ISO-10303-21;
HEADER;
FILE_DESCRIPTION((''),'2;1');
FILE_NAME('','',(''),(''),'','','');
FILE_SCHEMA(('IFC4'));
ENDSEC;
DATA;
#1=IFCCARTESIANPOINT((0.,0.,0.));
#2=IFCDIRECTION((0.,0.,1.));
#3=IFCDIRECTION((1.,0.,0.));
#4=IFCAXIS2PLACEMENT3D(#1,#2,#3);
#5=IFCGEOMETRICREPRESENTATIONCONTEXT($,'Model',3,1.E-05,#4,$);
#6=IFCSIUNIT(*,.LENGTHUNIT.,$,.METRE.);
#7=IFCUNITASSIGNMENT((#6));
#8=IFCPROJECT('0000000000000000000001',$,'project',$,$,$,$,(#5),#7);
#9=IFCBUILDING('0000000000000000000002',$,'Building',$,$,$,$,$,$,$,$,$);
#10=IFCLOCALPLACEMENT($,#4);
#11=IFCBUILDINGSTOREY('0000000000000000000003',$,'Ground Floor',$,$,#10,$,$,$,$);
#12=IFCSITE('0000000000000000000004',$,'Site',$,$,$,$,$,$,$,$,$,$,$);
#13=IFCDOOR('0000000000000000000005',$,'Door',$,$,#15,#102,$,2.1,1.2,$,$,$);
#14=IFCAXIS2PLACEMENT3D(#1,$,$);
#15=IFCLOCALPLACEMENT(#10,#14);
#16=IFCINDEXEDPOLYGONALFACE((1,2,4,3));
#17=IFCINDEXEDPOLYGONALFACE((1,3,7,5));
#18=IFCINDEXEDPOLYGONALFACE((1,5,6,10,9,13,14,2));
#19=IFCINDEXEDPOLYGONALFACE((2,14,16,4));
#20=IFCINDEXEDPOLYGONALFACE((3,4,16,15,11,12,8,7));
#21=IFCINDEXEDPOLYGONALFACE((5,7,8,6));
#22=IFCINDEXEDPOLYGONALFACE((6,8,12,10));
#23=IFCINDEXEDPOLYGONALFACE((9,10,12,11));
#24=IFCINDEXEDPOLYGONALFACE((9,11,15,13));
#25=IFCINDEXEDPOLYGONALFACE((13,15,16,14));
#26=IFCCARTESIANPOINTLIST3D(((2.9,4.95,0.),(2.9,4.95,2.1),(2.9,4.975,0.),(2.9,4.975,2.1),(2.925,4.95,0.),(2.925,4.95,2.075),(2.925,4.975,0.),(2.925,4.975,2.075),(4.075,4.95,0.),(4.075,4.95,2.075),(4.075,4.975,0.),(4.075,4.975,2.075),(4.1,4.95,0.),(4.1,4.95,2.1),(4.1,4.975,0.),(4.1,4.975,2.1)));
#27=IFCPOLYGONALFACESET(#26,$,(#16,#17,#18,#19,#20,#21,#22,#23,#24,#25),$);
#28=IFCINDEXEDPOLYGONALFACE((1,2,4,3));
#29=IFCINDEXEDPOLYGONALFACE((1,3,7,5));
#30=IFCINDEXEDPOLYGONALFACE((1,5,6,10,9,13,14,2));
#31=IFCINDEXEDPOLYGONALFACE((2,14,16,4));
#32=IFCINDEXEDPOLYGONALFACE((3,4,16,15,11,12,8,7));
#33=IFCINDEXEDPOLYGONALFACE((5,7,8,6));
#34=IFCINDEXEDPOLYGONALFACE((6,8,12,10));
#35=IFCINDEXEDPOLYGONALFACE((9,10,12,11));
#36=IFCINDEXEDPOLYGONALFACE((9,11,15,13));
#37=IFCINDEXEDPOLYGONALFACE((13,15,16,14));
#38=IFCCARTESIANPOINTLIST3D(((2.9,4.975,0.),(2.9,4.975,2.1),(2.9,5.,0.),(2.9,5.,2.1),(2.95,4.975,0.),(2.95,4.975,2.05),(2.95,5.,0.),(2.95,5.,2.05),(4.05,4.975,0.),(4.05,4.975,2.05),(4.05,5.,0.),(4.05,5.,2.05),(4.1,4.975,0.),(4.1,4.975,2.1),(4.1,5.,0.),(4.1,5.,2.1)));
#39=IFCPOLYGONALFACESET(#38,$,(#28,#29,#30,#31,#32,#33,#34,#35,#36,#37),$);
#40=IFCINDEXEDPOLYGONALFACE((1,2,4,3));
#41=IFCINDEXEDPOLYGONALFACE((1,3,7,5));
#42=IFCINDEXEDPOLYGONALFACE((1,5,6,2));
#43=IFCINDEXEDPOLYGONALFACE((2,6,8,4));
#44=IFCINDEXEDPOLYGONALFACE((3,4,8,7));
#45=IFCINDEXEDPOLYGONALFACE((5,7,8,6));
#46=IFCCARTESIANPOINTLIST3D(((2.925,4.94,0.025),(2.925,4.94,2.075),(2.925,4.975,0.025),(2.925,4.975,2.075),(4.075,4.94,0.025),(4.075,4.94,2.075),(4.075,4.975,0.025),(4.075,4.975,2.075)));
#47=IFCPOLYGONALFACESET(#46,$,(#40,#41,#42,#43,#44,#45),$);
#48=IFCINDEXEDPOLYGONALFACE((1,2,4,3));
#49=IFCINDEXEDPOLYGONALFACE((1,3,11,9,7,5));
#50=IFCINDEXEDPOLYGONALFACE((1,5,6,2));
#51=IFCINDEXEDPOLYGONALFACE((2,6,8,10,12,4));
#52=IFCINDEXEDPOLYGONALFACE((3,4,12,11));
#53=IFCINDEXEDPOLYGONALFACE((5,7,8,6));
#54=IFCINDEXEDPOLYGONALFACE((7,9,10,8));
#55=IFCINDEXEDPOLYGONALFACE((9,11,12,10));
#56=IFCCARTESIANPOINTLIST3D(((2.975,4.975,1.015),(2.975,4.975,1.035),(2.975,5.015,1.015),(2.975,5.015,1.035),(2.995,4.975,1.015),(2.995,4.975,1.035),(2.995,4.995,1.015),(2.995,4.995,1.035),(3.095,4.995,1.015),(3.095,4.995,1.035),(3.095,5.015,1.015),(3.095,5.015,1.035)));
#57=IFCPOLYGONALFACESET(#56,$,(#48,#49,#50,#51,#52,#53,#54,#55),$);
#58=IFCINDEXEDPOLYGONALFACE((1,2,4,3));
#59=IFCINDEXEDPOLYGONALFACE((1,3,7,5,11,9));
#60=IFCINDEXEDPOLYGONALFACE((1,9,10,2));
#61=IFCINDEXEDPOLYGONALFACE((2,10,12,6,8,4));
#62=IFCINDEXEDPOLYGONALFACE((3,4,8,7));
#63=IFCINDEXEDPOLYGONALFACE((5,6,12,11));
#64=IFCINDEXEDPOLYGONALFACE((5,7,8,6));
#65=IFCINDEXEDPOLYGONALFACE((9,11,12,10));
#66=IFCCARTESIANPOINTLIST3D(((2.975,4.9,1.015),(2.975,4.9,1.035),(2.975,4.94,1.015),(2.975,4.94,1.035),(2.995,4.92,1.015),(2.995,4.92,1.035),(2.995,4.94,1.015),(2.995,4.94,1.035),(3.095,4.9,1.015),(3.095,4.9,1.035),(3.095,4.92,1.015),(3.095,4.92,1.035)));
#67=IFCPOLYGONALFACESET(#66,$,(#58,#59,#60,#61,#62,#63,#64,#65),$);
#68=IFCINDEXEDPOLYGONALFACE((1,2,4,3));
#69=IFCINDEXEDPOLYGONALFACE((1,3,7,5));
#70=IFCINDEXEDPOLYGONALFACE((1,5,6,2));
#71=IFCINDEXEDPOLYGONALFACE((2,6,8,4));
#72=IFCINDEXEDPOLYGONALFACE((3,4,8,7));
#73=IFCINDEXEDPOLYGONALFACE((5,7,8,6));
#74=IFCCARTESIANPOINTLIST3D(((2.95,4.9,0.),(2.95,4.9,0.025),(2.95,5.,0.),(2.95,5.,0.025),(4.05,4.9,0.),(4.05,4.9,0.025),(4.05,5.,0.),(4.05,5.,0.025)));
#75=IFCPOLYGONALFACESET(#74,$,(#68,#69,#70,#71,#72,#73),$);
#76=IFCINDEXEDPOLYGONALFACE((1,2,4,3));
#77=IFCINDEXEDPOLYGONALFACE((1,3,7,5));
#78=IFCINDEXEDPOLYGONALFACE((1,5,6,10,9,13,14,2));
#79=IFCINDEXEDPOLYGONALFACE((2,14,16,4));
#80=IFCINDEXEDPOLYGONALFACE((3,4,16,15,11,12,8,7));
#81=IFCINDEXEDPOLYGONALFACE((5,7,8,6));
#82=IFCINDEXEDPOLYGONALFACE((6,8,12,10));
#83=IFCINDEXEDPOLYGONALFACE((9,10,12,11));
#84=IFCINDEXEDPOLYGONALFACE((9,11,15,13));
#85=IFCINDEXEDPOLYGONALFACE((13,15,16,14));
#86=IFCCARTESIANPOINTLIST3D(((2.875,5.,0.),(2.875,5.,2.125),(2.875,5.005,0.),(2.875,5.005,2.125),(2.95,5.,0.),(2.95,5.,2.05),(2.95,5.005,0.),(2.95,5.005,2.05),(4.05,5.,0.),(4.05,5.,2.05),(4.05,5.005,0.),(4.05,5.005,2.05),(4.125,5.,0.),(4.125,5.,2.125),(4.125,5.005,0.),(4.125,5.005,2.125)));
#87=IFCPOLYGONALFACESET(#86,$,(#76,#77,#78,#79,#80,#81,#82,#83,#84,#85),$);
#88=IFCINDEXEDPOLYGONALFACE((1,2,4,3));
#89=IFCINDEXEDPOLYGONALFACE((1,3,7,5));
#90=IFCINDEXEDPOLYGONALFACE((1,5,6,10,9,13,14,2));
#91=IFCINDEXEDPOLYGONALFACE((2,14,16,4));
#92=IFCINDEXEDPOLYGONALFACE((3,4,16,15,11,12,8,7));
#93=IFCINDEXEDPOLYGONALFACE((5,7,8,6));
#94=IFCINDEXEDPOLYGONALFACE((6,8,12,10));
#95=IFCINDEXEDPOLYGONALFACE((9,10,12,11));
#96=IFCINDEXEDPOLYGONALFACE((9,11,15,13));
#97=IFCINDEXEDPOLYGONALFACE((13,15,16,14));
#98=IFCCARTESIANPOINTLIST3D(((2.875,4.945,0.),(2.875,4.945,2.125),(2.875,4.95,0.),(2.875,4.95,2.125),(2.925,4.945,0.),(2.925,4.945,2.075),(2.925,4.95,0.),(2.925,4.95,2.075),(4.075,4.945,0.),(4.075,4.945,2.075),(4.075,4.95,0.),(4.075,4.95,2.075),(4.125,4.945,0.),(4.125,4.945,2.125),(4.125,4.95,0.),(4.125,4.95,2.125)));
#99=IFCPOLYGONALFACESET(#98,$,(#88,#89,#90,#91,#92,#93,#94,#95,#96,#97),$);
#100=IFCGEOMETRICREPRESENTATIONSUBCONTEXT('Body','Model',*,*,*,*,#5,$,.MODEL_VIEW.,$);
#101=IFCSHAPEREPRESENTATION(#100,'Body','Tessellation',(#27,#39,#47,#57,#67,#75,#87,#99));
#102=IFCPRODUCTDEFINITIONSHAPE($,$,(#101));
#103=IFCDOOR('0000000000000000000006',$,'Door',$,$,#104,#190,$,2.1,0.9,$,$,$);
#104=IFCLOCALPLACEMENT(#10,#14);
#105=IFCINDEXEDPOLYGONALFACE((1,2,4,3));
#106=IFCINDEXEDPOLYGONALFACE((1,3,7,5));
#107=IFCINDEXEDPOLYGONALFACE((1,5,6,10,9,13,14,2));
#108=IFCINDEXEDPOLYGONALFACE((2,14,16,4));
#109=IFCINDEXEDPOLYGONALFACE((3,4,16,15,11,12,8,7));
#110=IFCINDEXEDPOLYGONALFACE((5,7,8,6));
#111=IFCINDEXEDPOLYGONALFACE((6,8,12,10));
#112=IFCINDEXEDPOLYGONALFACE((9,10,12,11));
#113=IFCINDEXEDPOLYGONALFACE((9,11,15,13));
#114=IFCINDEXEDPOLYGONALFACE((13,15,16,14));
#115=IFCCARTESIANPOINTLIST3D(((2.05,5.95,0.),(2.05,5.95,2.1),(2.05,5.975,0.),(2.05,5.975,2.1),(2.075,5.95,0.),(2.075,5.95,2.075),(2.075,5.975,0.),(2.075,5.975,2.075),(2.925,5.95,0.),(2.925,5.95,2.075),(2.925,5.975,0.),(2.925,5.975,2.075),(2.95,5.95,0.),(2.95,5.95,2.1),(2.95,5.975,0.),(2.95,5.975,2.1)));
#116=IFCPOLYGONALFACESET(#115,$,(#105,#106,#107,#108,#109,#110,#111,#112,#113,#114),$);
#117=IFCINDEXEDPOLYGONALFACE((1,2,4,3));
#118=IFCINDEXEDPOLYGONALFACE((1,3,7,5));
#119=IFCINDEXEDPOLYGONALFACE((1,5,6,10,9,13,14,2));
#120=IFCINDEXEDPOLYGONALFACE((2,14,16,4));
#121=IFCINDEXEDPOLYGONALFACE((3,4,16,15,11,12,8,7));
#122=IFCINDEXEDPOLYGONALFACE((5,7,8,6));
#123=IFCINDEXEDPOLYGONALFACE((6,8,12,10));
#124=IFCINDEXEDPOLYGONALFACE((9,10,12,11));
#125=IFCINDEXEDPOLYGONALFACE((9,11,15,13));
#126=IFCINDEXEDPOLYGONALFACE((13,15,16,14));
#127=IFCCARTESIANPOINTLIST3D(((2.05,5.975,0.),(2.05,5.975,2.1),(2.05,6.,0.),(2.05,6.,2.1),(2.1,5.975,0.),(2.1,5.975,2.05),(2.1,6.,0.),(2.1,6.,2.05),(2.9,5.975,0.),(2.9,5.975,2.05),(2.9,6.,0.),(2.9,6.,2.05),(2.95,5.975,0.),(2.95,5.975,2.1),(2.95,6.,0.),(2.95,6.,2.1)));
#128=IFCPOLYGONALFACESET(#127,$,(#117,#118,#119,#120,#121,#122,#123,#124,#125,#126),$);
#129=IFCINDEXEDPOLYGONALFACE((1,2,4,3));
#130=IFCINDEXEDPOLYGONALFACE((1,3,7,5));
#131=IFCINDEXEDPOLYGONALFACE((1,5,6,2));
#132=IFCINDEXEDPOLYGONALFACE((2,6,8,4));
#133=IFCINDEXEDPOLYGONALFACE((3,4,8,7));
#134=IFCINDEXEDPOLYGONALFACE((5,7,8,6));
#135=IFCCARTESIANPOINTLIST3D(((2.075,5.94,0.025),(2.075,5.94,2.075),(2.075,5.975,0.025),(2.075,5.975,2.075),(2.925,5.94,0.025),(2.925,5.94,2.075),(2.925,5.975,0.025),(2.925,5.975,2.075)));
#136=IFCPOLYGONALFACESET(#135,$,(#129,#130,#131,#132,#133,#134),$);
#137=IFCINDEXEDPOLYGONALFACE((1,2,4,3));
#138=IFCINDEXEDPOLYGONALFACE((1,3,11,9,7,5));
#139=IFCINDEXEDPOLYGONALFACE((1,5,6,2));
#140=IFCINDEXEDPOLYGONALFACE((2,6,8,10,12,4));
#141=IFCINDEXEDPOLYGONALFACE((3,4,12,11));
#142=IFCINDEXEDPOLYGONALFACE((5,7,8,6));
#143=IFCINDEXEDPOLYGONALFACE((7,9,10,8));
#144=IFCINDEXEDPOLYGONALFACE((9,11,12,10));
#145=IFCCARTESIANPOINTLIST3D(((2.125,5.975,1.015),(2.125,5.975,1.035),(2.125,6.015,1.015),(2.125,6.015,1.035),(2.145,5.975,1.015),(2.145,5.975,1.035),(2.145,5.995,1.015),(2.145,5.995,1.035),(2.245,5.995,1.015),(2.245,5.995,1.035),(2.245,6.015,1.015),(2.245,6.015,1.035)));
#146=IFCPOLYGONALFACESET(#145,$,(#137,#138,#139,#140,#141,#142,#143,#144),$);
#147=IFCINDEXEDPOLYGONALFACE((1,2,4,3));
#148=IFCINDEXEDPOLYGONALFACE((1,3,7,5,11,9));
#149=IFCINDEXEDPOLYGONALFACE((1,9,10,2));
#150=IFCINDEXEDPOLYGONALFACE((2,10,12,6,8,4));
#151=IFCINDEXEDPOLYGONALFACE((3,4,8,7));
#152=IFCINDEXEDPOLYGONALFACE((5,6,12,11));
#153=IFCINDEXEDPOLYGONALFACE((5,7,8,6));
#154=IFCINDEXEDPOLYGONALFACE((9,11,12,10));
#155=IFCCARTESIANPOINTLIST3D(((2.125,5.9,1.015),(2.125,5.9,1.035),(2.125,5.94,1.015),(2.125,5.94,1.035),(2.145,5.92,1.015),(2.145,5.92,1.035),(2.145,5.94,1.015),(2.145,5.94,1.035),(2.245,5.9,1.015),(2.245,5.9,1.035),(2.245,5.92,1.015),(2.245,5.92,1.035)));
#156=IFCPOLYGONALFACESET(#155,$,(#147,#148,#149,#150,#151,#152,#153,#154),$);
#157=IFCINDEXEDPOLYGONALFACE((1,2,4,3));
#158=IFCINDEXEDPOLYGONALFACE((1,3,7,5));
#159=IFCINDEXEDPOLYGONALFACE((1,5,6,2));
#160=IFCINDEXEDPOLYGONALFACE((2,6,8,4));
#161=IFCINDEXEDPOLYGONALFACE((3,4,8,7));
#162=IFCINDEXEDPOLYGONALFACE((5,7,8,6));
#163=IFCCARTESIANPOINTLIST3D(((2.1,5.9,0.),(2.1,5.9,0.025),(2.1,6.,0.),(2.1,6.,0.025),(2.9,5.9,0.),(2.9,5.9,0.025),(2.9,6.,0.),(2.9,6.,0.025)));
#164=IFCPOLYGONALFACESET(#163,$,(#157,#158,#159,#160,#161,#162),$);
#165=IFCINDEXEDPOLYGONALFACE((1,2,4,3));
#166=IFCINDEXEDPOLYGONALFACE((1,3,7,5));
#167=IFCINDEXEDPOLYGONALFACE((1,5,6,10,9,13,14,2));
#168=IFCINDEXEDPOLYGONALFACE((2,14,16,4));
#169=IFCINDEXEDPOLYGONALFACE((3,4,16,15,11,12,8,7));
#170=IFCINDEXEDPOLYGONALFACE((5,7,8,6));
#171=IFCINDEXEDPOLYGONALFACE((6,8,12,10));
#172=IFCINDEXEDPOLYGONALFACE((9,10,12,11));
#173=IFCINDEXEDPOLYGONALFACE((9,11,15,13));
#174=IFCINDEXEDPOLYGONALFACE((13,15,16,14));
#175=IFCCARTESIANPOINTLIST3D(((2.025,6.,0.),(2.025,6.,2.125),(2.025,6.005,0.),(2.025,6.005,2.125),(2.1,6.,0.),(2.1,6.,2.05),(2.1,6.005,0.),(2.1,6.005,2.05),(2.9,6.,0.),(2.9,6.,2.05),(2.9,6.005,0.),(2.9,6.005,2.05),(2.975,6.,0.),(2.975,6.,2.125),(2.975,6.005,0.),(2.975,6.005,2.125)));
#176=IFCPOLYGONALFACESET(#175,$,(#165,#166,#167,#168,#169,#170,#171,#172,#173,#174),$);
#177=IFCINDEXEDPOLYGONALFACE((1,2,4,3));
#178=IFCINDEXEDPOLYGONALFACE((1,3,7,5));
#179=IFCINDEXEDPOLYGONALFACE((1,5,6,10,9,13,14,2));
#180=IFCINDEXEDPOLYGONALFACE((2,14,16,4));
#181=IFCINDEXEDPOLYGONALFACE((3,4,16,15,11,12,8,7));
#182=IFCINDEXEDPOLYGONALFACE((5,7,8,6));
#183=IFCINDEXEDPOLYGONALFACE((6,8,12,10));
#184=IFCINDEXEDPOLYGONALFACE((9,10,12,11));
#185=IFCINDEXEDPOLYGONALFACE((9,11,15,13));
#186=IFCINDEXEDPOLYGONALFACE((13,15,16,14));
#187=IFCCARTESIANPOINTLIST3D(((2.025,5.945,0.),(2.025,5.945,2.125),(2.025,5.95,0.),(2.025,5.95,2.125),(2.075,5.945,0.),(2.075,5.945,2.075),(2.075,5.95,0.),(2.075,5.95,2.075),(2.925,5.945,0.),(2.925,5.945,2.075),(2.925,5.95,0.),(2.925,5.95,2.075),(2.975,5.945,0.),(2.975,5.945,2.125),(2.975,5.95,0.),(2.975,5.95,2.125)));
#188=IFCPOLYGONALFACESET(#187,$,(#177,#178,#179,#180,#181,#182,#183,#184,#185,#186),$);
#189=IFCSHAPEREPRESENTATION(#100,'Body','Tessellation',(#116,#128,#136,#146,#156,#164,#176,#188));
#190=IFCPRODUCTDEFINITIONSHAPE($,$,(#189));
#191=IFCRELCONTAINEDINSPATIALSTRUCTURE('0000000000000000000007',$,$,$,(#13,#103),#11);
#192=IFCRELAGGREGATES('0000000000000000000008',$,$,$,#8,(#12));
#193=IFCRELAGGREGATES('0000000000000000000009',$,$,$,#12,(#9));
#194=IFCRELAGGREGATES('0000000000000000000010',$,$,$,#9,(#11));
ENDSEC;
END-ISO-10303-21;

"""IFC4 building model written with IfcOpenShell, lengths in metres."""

from ifc_helpers import new_model, si_unit, frame, origin_with_axes, place, context, subcontext, project, spatial, line, indexed_curve, outline, extrude, element, save


model = new_model("IFC4")

# Units and contexts
model_context = context("Model", 3, precision=1e-05, world=origin_with_axes())
body_context = subcontext(model_context, "Body", "Model", "MODEL_VIEW")
ifc_project = project(units=[si_unit("LENGTHUNIT", "METRE")], contexts=[model_context])

# Site, building, storey
site = spatial("IfcSite", under=ifc_project, Name="Site")
building = spatial("IfcBuilding", under=site, Name="Building")
storey_placement = place(None, origin_with_axes())
storey = spatial("IfcBuildingStorey", under=building, at=storey_placement, Name="Ground Floor")

# Doors
door_1_placement = place(storey_placement, frame((4.1, 5.0, 0.0), z_axis=(0.0, 0.0, 1.0), x_axis=(-1.0, 0.0, 0.0)))
element("IfcDoor", 1, at=door_1_placement, inside=storey, Name="Door", OverallHeight=2.1, OverallWidth=1.2, context=body_context, shape_type="SweptSolid", body=[
    extrude(outline(indexed_curve([(0.0, 0.0), (0.0, 2.1), (1.2, 2.1), (1.2, 0.0), (1.175, 0.0), (1.175, 2.075), (0.025, 2.075), (0.025, 0.0)], segments=[line(1, 2, 3, 4, 5, 6, 7, 8, 1)])), frame((0.0, 0.025, 0.0), z_axis=(0.0, -1.0, 0.0), x_axis=(1.0, 0.0, 0.0)), (0.0, 0.0, -1.0), 0.025),
    extrude(outline(indexed_curve([(0.0, 0.0), (0.0, 2.1), (1.2, 2.1), (1.2, 0.0), (1.15, 0.0), (1.15, 2.05), (0.05, 2.05), (0.05, 0.0)], segments=[line(1, 2, 3, 4, 5, 6, 7, 8, 1)])), frame((0.0, 0.0, 0.0), z_axis=(0.0, -1.0, 0.0), x_axis=(1.0, 0.0, 0.0)), (0.0, 0.0, -1.0), 0.025),
    extrude(outline(indexed_curve([(0.0, 0.0), (1.15, 0.0), (1.15, 0.035), (0.0, 0.035)], segments=[line(1, 2, 3, 4, 1)])), frame((0.025, 0.025, 0.025), z_axis=(0.0, 0.0, 1.0), x_axis=(1.0, 0.0, 0.0)), (0.0, 0.0, 1.0), 2.05),
    extrude(outline(indexed_curve([(0.0, 0.0), (0.0, -0.04), (-0.12, -0.04), (-0.12, -0.02), (-0.02, -0.02), (-0.02, 0.0)], segments=[line(1, 2, 3, 4, 5, 6, 1)])), frame((1.125, 0.025, 1.015), z_axis=(0.0, 0.0, 1.0), x_axis=(1.0, 0.0, 0.0)), (0.0, 0.0, 1.0), 0.02),
    extrude(outline(indexed_curve([(0.0, 0.0), (0.0, 0.04), (-0.12, 0.04), (-0.12, 0.02), (-0.02, 0.02), (-0.02, 0.0)], segments=[line(1, 2, 3, 4, 5, 6, 1)])), frame((1.125, 0.06, 1.015), z_axis=(0.0, 0.0, 1.0), x_axis=(1.0, 0.0, 0.0)), (0.0, 0.0, 1.0), 0.02),
    extrude(outline(indexed_curve([(0.0, 0.0), (1.1, 0.0), (1.1, 0.1), (0.0, 0.1)], segments=[line(1, 2, 3, 4, 1)])), frame((0.05, 0.0, 0.0), z_axis=(0.0, 0.0, 1.0), x_axis=(1.0, 0.0, 0.0)), (0.0, 0.0, 1.0), 0.025),
    extrude(outline(indexed_curve([(0.0, 0.0), (0.0, 2.125), (1.25, 2.125), (1.25, 0.0), (1.175, 0.0), (1.175, 2.05), (0.075, 2.05), (0.075, 0.0)], segments=[line(1, 2, 3, 4, 5, 6, 7, 8, 1)])), frame((-0.025, -0.005, 0.0), z_axis=(0.0, -1.0, 0.0), x_axis=(1.0, 0.0, 0.0)), (0.0, 0.0, -1.0), 0.005),
    extrude(outline(indexed_curve([(0.0, 0.0), (0.0, 2.125), (1.25, 2.125), (1.25, 0.0), (1.2, 0.0), (1.2, 2.075), (0.05, 2.075), (0.05, 0.0)], segments=[line(1, 2, 3, 4, 5, 6, 7, 8, 1)])), frame((-0.025, 0.05, 0.0), z_axis=(0.0, -1.0, 0.0), x_axis=(1.0, 0.0, 0.0)), (0.0, 0.0, -1.0), 0.005),
])
door_2_placement = place(storey_placement, frame((2.95, 6.0, 0.0), z_axis=(0.0, 0.0, 1.0), x_axis=(-1.0, 0.0, 0.0)))
element("IfcDoor", 2, at=door_2_placement, inside=storey, Name="Door", OverallHeight=2.1, OverallWidth=0.9, context=body_context, shape_type="SweptSolid", body=[
    extrude(outline(indexed_curve([(0.0, 0.0), (0.0, 2.1), (0.9, 2.1), (0.9, 0.0), (0.875, 0.0), (0.875, 2.075), (0.025, 2.075), (0.025, 0.0)], segments=[line(1, 2, 3, 4, 5, 6, 7, 8, 1)])), frame((0.0, 0.025, 0.0), z_axis=(0.0, -1.0, 0.0), x_axis=(1.0, 0.0, 0.0)), (0.0, 0.0, -1.0), 0.025),
    extrude(outline(indexed_curve([(0.0, 0.0), (0.0, 2.1), (0.9, 2.1), (0.9, 0.0), (0.85, 0.0), (0.85, 2.05), (0.05, 2.05), (0.05, 0.0)], segments=[line(1, 2, 3, 4, 5, 6, 7, 8, 1)])), frame((0.0, 0.0, 0.0), z_axis=(0.0, -1.0, 0.0), x_axis=(1.0, 0.0, 0.0)), (0.0, 0.0, -1.0), 0.025),
    extrude(outline(indexed_curve([(0.0, 0.0), (0.85, 0.0), (0.85, 0.035), (0.0, 0.035)], segments=[line(1, 2, 3, 4, 1)])), frame((0.025, 0.025, 0.025), z_axis=(0.0, 0.0, 1.0), x_axis=(1.0, 0.0, 0.0)), (0.0, 0.0, 1.0), 2.05),
    extrude(outline(indexed_curve([(0.0, 0.0), (0.0, -0.04), (-0.12, -0.04), (-0.12, -0.02), (-0.02, -0.02), (-0.02, 0.0)], segments=[line(1, 2, 3, 4, 5, 6, 1)])), frame((0.825, 0.025, 1.015), z_axis=(0.0, 0.0, 1.0), x_axis=(1.0, 0.0, 0.0)), (0.0, 0.0, 1.0), 0.02),
    extrude(outline(indexed_curve([(0.0, 0.0), (0.0, 0.04), (-0.12, 0.04), (-0.12, 0.02), (-0.02, 0.02), (-0.02, 0.0)], segments=[line(1, 2, 3, 4, 5, 6, 1)])), frame((0.825, 0.06, 1.015), z_axis=(0.0, 0.0, 1.0), x_axis=(1.0, 0.0, 0.0)), (0.0, 0.0, 1.0), 0.02),
    extrude(outline(indexed_curve([(0.0, 0.0), (0.8, 0.0), (0.8, 0.1), (0.0, 0.1)], segments=[line(1, 2, 3, 4, 1)])), frame((0.05, 0.0, 0.0), z_axis=(0.0, 0.0, 1.0), x_axis=(1.0, 0.0, 0.0)), (0.0, 0.0, 1.0), 0.025),
    extrude(outline(indexed_curve([(0.0, 0.0), (0.0, 2.125), (0.95, 2.125), (0.95, 0.0), (0.875, 0.0), (0.875, 2.05), (0.075, 2.05), (0.075, 0.0)], segments=[line(1, 2, 3, 4, 5, 6, 7, 8, 1)])), frame((-0.025, -0.005, 0.0), z_axis=(0.0, -1.0, 0.0), x_axis=(1.0, 0.0, 0.0)), (0.0, 0.0, -1.0), 0.005),
    extrude(outline(indexed_curve([(0.0, 0.0), (0.0, 2.125), (0.95, 2.125), (0.95, 0.0), (0.9, 0.0), (0.9, 2.075), (0.05, 2.075), (0.05, 0.0)], segments=[line(1, 2, 3, 4, 5, 6, 7, 8, 1)])), frame((-0.025, 0.05, 0.0), z_axis=(0.0, -1.0, 0.0), x_axis=(1.0, 0.0, 0.0)), (0.0, 0.0, -1.0), 0.005),
])

save(model, "model.ifc")
